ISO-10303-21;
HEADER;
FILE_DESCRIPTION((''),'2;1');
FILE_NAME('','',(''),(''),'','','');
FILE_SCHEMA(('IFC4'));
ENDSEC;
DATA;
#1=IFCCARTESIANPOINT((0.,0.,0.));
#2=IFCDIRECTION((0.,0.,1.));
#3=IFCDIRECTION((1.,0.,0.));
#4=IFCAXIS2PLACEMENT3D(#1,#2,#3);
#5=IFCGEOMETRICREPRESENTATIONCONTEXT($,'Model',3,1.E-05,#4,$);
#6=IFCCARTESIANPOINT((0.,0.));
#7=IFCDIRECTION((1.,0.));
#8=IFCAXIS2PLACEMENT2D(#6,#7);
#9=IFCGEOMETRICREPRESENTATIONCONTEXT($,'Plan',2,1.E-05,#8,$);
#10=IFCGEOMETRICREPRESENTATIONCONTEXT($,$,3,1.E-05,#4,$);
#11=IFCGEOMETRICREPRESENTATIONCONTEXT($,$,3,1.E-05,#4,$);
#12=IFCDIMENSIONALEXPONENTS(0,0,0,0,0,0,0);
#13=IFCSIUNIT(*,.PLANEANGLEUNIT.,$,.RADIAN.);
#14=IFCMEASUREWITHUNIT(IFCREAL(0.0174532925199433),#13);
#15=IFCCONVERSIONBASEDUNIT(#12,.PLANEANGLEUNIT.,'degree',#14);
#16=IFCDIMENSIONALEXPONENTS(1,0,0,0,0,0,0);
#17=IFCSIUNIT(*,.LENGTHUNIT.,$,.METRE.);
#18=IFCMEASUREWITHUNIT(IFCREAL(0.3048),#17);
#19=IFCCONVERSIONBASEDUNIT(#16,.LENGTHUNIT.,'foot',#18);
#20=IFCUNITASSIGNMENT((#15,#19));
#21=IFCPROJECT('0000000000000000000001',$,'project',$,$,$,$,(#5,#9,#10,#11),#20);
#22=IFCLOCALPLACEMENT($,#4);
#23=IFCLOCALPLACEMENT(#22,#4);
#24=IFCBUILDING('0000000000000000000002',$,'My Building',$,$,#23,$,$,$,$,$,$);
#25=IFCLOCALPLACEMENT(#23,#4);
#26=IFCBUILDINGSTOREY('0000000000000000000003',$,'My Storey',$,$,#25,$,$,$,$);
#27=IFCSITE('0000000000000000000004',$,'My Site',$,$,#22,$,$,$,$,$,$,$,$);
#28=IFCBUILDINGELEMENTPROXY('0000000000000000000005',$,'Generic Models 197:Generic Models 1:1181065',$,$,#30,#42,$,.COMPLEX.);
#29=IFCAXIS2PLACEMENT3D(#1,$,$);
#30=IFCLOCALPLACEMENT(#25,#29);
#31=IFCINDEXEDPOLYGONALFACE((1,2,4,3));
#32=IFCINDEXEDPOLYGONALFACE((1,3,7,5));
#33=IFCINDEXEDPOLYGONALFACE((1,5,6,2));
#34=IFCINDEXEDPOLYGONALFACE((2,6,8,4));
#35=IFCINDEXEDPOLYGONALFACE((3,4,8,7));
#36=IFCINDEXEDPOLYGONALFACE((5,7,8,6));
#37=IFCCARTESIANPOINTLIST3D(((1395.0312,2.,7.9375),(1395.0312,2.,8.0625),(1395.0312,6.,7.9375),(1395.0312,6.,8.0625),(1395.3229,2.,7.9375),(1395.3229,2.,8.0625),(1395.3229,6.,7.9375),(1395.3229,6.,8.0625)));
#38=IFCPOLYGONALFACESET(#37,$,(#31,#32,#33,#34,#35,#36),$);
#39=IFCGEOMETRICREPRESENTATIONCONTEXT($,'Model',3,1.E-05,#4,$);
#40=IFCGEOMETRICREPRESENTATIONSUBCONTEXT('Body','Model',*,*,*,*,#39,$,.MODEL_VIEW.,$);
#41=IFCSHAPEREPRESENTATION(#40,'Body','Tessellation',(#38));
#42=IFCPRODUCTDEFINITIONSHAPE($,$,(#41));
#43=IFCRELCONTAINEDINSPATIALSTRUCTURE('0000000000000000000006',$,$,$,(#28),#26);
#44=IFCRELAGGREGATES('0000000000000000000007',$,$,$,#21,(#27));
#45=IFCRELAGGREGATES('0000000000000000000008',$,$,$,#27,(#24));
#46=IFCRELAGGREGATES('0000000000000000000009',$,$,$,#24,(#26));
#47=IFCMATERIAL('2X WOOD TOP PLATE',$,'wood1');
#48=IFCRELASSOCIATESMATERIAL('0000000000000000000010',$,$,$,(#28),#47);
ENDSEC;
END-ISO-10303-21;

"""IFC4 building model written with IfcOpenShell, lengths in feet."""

from ifc_helpers import new_model, entity, si_unit, converted_unit, frame, origin_with_axes, origin_2d_with_axis, place, context, subcontext, project, spatial, polyline, outline, extrude, material, element, save


model = new_model("IFC4")

# Units and contexts
model_context_1 = context("Model", 3, precision=1e-05, world=origin_with_axes())
plan_context = context("Plan", 2, precision=1e-05, world=origin_2d_with_axis())
model_context_2 = context("Model", 3, precision=1e-05, world=origin_with_axes())
context_of_model_1 = context(None, 3, precision=1e-05, world=origin_with_axes())
context_of_model_2 = context(None, 3, precision=1e-05, world=origin_with_axes())
body_context_1 = subcontext(model_context_2, "Body", "Model", "MODEL_VIEW")
ifc_project = project(units=[converted_unit("PLANEANGLEUNIT", "degree", entity("IfcReal", 0.0174532925199433), si_unit("PLANEANGLEUNIT", "RADIAN"), dimensions=[0, 0, 0, 0, 0, 0, 0]), converted_unit("LENGTHUNIT", "foot", entity("IfcReal", 0.3048), si_unit("LENGTHUNIT", "METRE"), dimensions=[1, 0, 0, 0, 0, 0, 0])], contexts=[model_context_1, plan_context, context_of_model_1, context_of_model_2])

# Site, building, storey
site_placement = place(None, origin_with_axes())
site = spatial("IfcSite", under=ifc_project, at=site_placement, Name="My Site")
building_placement = place(site_placement, origin_with_axes())
building = spatial("IfcBuilding", under=site, at=building_placement, Name="My Building")
storey_placement = place(building_placement, origin_with_axes())
storey = spatial("IfcBuildingStorey", under=building, at=storey_placement, Name="My Storey")

# Building element proxy
ifc_material_1 = material(Name="2X WOOD TOP PLATE", Category="wood1")
proxy_1_placement = place(storey_placement, frame((1395.0312, 6.0, 8.0625), z_axis=(0.0, -1.0, 0.0), x_axis=(1.0, 0.0, 0.0)))
element("IfcBuildingElementProxy", 1, at=proxy_1_placement, inside=storey, material=ifc_material_1, Name="Generic Models 197:Generic Models 1:1181065", PredefinedType="COMPLEX", context=body_context_1, shape_type="SweptSolid", body=[
    extrude(outline(polyline([(-0.0625, -0.1458), (0.0625, -0.1458), (0.0625, 0.1458), (-0.0625, 0.1458), (-0.0625, -0.1458)])), frame((0.1458, -0.0625, 0.0), z_axis=(0.0, 0.0, -1.0), x_axis=(0.0, -1.0, 0.0)), (0.0, 0.0, -1.0), 4.0),
])

save(model, "model.ifc")
